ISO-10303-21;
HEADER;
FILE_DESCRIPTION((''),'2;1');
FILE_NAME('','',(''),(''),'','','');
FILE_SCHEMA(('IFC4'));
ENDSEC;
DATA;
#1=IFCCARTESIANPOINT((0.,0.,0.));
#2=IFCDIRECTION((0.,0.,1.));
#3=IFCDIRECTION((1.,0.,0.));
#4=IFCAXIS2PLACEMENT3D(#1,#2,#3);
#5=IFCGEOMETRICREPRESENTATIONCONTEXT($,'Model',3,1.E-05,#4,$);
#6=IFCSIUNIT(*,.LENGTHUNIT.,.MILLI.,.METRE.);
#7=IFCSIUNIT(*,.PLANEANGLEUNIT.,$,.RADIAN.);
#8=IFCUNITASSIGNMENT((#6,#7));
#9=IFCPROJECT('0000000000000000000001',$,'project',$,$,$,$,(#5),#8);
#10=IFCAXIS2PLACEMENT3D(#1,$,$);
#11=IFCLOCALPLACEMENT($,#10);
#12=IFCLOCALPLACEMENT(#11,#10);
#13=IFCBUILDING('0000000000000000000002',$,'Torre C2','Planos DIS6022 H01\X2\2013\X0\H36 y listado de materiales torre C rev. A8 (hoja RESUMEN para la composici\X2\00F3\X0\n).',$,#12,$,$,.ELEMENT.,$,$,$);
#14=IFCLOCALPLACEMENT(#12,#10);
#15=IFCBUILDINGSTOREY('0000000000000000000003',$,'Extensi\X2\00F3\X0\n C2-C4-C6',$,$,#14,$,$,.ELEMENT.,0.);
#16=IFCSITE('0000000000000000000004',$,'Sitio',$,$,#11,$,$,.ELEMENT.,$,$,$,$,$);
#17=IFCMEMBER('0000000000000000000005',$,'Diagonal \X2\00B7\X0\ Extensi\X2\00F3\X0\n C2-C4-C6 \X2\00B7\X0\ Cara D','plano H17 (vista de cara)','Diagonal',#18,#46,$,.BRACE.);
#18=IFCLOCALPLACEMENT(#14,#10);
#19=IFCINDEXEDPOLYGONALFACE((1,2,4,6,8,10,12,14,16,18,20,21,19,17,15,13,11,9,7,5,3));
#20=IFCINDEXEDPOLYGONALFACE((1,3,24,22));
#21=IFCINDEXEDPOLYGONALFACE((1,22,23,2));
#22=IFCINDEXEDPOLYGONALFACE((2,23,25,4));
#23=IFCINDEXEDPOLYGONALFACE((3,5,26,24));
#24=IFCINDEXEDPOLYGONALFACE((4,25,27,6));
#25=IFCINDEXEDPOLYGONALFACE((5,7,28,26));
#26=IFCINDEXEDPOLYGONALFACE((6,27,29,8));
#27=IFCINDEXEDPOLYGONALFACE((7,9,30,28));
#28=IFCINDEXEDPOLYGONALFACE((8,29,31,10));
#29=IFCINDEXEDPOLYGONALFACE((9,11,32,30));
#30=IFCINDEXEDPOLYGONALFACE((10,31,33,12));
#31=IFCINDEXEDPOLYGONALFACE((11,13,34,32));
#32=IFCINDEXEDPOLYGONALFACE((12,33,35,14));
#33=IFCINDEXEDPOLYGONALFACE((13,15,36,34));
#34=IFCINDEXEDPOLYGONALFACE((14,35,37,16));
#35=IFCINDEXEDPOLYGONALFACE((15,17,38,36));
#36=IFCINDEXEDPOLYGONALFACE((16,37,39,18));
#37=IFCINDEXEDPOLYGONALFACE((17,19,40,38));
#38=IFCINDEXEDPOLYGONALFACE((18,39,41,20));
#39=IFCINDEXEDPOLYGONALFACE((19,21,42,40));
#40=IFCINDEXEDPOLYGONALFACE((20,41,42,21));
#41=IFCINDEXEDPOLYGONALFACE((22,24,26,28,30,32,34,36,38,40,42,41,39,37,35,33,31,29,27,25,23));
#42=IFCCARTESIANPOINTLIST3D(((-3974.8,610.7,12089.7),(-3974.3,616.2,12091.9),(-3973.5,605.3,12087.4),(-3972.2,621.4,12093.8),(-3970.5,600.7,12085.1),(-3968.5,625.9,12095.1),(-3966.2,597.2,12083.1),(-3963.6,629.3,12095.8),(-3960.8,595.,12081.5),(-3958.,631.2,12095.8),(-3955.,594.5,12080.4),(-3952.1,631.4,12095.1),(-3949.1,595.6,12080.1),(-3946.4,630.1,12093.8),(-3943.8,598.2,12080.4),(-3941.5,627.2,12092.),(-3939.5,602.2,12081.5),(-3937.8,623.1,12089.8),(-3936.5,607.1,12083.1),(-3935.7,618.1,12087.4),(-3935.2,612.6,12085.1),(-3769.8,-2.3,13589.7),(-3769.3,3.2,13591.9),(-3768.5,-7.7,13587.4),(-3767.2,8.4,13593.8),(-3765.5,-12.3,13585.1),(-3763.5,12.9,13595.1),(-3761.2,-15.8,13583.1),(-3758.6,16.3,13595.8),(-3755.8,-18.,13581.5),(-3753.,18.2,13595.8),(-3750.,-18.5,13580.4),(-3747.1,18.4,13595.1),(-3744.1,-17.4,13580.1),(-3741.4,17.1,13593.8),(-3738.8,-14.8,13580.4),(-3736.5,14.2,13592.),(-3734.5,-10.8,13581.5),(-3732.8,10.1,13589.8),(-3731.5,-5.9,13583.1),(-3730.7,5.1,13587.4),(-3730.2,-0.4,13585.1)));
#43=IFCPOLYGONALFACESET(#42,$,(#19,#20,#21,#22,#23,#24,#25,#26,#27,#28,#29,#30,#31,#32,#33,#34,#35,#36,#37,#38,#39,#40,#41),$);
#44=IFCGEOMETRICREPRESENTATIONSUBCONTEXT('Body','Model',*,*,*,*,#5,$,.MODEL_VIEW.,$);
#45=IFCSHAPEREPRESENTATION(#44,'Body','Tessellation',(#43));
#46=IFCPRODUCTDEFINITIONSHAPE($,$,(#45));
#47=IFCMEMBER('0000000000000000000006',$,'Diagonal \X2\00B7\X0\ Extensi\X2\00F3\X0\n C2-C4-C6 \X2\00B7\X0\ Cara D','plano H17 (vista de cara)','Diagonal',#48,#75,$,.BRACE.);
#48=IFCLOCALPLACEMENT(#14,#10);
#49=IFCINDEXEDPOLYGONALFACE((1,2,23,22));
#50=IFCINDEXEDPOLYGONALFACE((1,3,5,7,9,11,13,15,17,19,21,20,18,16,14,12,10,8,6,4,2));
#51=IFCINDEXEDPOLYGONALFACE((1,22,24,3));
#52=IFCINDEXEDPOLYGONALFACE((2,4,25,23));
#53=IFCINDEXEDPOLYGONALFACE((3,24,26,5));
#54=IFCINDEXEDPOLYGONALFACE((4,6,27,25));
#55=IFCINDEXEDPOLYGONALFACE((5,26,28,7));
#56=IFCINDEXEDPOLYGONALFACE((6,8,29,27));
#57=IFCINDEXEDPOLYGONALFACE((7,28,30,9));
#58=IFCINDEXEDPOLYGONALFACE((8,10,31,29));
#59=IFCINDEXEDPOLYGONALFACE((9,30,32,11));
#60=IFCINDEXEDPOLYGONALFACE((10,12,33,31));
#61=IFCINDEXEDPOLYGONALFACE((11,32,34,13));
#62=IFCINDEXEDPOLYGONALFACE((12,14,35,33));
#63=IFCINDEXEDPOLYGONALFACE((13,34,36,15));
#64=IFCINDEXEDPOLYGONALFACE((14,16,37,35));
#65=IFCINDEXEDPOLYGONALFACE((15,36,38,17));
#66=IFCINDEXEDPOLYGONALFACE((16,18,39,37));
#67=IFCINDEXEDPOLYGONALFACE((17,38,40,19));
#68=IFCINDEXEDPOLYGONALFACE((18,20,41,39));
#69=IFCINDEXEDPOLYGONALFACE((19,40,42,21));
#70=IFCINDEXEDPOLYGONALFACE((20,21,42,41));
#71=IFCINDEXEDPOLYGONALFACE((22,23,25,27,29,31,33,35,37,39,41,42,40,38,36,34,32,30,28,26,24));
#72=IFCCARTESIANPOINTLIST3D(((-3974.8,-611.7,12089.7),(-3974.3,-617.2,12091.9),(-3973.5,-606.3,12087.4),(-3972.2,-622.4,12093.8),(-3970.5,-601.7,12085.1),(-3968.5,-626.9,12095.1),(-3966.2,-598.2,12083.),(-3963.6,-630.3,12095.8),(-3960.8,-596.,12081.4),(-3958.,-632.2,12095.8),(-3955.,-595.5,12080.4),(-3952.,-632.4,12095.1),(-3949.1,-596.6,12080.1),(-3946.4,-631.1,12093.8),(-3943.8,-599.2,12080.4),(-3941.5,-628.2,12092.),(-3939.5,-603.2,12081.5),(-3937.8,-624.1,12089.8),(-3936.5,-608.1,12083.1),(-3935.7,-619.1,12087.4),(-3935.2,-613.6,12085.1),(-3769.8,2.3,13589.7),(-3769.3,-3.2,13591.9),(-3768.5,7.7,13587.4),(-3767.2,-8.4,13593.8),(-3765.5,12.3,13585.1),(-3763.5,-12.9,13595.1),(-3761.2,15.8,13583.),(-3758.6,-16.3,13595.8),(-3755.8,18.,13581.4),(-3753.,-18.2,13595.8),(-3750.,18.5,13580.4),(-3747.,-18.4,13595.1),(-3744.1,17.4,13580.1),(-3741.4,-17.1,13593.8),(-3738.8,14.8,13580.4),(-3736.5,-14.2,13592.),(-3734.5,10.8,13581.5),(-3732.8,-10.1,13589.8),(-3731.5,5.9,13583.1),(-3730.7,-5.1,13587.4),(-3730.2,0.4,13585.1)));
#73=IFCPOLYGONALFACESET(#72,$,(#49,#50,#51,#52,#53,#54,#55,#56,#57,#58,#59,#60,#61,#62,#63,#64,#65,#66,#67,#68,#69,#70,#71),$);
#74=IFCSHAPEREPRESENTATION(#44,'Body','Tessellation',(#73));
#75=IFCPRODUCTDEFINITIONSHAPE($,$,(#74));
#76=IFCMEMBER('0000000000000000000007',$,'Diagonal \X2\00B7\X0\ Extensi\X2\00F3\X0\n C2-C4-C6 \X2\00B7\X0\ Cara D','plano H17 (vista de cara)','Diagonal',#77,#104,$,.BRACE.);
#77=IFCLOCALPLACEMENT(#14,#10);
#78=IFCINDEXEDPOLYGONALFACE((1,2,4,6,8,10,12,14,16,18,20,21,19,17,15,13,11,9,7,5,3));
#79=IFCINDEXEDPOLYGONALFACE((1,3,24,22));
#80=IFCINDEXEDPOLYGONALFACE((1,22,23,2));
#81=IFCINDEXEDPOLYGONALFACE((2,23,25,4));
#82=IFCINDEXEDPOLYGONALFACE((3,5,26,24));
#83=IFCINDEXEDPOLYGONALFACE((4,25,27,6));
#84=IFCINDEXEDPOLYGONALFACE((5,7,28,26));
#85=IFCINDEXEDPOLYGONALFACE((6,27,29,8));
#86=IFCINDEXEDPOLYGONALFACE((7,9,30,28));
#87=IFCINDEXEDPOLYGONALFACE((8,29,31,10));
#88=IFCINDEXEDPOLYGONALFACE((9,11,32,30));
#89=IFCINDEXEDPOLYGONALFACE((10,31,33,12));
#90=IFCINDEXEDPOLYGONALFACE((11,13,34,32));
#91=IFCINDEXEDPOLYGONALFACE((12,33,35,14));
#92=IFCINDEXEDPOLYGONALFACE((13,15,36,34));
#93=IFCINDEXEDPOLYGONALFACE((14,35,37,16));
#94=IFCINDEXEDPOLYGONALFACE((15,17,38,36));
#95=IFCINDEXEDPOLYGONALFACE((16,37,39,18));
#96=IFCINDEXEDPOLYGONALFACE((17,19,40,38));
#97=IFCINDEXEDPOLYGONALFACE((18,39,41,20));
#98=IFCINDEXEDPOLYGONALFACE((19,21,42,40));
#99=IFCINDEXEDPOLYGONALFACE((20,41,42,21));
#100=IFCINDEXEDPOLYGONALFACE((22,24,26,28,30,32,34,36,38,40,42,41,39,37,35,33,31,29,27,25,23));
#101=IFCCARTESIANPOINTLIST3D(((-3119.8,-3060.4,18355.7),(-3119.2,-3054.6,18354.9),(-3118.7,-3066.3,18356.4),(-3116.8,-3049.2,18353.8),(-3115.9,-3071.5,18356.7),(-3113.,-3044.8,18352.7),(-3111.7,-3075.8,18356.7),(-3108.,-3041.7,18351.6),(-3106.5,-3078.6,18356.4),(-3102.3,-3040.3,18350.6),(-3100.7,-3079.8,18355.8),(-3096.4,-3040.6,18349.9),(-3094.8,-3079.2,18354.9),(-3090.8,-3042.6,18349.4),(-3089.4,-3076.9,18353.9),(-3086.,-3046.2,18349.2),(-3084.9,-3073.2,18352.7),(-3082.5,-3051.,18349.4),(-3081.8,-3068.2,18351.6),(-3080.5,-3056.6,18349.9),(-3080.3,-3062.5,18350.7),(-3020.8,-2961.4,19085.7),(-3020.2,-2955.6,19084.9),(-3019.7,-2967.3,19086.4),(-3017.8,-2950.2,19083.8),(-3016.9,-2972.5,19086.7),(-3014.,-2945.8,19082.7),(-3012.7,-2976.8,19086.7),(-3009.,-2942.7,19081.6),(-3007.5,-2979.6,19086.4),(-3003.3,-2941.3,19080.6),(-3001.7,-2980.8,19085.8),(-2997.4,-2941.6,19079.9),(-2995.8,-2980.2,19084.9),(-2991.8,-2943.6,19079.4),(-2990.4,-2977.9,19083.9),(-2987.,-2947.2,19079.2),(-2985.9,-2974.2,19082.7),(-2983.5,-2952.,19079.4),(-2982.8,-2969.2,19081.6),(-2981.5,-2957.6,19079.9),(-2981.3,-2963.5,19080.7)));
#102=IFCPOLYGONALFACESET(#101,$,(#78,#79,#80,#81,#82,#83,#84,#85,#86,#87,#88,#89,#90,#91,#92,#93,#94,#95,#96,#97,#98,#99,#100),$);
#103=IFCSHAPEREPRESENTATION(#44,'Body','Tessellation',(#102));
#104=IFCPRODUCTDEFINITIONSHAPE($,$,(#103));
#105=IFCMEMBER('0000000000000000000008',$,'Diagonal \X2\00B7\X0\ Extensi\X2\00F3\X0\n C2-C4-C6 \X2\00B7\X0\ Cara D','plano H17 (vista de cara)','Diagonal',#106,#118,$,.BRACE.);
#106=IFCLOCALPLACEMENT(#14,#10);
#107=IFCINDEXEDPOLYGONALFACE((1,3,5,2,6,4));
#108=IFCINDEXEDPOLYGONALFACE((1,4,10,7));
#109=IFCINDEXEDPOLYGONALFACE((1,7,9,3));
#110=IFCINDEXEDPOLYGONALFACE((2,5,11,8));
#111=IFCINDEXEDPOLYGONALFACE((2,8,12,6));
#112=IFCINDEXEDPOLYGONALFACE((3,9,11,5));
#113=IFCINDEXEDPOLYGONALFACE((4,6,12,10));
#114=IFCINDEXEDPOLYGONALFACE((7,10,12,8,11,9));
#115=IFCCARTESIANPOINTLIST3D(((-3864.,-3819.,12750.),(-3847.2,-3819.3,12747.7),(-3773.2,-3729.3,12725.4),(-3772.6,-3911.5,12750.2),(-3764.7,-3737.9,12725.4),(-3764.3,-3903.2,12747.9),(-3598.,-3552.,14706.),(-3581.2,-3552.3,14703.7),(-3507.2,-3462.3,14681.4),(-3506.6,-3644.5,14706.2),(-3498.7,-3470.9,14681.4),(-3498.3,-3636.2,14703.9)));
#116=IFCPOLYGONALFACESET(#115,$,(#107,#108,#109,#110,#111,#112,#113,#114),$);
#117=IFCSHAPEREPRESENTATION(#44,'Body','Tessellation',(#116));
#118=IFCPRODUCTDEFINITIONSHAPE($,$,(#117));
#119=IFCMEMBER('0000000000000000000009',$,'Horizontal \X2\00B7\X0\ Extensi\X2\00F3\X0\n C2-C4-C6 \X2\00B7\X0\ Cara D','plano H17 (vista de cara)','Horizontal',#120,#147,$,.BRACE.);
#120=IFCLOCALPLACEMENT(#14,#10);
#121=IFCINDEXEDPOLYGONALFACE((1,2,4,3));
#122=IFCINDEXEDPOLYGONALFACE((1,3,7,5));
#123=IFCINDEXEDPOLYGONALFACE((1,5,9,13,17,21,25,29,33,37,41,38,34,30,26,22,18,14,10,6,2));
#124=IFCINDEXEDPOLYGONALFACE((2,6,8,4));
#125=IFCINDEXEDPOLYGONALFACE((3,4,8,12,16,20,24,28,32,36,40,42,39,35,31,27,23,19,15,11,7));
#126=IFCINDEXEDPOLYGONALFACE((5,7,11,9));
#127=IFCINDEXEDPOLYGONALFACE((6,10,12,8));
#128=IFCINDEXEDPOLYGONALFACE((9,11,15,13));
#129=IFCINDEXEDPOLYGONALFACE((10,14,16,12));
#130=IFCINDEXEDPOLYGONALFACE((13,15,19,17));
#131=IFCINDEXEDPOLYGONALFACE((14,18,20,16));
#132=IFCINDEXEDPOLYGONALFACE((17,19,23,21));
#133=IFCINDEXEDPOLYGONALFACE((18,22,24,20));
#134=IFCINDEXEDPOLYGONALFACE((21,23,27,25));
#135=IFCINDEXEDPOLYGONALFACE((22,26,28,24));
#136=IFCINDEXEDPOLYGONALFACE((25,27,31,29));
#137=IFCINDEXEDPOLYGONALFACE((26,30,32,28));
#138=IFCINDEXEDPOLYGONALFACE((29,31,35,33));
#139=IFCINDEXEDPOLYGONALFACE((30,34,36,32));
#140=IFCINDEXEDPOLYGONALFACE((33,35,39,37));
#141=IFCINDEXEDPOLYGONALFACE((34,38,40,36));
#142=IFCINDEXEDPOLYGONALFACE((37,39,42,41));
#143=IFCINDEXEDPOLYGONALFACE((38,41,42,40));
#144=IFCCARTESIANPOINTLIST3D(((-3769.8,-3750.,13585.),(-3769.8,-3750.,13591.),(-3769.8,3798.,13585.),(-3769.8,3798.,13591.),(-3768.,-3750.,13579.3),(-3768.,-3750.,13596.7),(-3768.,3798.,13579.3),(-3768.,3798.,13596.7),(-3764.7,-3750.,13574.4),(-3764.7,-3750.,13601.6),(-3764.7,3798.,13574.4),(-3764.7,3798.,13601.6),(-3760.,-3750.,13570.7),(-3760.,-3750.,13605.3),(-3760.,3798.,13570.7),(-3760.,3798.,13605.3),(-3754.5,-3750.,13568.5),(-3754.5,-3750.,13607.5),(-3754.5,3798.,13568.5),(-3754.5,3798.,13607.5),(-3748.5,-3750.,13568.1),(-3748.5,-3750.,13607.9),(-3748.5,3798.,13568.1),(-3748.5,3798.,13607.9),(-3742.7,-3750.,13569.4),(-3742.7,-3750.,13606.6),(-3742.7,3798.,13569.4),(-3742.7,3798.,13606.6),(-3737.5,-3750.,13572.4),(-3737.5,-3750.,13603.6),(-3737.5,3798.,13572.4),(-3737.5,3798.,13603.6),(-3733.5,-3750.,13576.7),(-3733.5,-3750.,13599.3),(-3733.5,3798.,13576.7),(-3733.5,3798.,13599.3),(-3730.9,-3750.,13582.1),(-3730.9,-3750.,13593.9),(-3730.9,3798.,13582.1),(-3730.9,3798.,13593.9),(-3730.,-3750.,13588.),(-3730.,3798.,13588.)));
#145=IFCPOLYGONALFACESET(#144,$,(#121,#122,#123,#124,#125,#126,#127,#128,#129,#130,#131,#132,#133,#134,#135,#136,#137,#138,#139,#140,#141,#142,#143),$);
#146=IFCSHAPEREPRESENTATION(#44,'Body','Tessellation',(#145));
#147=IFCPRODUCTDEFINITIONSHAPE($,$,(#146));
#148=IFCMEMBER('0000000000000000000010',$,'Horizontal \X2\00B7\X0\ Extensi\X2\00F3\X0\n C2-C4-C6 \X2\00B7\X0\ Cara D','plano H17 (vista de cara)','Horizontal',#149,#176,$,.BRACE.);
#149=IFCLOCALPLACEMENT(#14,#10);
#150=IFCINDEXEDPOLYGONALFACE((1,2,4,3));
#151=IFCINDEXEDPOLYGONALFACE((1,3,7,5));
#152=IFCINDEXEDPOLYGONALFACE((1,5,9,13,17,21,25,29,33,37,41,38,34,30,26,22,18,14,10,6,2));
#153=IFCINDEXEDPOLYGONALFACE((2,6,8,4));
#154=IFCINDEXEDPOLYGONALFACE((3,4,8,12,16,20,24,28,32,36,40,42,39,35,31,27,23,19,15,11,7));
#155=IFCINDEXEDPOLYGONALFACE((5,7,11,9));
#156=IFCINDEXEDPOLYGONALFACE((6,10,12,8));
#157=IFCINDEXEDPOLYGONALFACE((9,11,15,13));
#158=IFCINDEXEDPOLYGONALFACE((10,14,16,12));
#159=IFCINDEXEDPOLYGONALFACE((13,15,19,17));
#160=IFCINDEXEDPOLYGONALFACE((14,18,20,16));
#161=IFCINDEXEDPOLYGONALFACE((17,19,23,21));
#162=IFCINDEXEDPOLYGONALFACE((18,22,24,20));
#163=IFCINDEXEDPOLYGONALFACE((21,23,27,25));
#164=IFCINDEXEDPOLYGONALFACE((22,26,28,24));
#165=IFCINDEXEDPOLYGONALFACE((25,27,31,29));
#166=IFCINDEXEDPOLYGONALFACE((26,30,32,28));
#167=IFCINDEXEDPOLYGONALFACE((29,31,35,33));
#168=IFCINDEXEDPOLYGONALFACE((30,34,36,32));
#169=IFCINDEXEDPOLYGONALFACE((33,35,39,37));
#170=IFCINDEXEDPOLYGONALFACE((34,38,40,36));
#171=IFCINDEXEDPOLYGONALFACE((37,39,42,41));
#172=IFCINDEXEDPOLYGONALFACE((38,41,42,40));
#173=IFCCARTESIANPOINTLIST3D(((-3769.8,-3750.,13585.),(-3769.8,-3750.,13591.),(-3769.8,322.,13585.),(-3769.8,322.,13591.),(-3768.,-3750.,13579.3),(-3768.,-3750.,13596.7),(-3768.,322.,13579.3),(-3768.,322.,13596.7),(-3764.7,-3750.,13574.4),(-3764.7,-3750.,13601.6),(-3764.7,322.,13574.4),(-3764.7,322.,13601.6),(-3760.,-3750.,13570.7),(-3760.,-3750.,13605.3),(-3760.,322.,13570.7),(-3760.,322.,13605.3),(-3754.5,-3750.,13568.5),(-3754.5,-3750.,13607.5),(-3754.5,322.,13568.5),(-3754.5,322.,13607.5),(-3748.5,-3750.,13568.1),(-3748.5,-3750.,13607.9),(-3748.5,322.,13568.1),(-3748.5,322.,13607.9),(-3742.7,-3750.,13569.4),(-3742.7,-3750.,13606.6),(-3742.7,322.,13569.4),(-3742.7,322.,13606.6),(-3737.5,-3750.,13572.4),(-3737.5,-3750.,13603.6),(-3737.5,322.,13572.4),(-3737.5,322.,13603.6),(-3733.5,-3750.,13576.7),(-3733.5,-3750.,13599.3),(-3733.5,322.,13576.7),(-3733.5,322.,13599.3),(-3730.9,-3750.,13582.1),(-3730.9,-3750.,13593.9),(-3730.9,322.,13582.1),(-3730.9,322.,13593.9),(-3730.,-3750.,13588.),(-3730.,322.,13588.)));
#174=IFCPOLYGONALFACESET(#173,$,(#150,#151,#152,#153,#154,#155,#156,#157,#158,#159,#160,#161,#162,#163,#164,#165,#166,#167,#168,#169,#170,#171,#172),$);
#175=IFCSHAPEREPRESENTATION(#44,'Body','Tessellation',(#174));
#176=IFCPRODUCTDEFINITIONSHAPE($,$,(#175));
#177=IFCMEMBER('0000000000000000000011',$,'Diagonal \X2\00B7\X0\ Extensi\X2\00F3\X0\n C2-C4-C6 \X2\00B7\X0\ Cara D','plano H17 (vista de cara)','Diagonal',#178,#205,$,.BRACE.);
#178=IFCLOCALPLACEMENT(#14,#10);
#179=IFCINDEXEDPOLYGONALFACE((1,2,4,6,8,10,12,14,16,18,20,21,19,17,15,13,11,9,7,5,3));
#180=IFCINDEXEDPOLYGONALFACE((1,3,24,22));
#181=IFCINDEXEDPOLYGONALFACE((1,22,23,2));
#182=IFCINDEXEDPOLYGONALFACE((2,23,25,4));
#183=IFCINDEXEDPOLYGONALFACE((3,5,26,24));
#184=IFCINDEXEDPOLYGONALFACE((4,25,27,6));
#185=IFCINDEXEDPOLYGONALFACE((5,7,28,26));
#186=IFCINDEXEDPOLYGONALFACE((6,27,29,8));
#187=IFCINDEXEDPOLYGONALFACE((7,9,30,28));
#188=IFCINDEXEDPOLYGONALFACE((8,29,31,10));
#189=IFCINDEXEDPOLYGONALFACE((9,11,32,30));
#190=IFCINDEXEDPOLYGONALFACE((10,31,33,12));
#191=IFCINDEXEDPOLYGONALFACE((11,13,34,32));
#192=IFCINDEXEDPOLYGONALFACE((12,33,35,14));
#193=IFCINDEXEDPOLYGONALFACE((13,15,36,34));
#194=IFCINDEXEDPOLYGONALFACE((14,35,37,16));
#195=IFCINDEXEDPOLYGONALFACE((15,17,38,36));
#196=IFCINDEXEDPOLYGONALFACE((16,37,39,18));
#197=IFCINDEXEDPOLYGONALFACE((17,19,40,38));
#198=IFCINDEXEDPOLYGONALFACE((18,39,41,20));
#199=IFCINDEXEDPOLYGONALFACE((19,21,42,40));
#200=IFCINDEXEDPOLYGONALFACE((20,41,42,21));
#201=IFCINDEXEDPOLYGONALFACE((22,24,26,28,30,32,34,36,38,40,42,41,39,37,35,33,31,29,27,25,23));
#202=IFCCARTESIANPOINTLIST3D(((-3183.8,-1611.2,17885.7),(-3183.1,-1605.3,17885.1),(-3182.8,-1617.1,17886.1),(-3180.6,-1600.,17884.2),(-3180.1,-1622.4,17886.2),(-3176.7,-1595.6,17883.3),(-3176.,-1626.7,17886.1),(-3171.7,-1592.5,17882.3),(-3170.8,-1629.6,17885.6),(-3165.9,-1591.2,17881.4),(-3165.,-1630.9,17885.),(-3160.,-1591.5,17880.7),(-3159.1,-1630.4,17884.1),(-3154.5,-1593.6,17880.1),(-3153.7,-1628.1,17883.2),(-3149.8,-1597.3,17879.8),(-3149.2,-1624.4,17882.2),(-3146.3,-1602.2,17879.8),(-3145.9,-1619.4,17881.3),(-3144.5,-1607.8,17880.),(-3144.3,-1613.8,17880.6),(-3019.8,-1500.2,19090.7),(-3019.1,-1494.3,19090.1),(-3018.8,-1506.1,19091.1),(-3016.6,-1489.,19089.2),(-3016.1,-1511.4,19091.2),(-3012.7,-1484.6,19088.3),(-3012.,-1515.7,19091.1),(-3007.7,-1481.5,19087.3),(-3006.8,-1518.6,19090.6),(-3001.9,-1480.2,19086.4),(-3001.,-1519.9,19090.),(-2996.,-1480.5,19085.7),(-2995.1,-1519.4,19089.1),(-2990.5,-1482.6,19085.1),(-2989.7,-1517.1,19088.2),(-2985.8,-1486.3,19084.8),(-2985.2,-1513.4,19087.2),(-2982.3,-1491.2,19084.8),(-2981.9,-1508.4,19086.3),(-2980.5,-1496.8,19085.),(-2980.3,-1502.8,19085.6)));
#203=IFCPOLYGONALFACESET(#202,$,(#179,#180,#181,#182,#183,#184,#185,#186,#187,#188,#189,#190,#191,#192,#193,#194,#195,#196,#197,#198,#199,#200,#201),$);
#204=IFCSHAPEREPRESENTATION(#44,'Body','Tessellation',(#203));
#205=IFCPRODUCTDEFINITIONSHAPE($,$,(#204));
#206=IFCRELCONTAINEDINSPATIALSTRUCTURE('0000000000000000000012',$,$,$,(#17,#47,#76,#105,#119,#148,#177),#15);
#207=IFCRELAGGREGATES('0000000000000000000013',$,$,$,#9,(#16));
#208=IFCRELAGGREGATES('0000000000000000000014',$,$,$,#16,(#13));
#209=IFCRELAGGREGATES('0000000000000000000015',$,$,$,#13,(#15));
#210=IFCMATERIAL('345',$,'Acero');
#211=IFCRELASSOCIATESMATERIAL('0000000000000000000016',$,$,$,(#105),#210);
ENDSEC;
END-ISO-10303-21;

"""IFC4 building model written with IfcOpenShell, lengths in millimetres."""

from ifc_helpers import new_model, si_unit, frame, frame_2d, origin, origin_with_axes, place, context, subcontext, project, spatial, circle, l_section, extrude, material, element, save


model = new_model("IFC4")

# Units and contexts
model_context = context("Model", 3, precision=1e-05, world=origin_with_axes())
body_context = subcontext(model_context, "Body", "Model", "MODEL_VIEW")
ifc_project = project(units=[si_unit("LENGTHUNIT", "METRE", prefix="MILLI"), si_unit("PLANEANGLEUNIT", "RADIAN")], contexts=[model_context])

# Site, building, storey
site_placement = place(None, origin())
site = spatial("IfcSite", under=ifc_project, at=site_placement, Name="Sitio", CompositionType="ELEMENT")
building_placement = place(site_placement, origin())
building = spatial("IfcBuilding", under=site, at=building_placement, Name="Torre C2", Description="Planos DIS6022 H01–H36 y listado de materiales torre C rev. A8 (hoja RESUMEN para la composición).", CompositionType="ELEMENT")
storey_placement = place(building_placement, origin())
storey = spatial("IfcBuildingStorey", under=building, at=storey_placement, Name="Extensión C2-C4-C6", CompositionType="ELEMENT", Elevation=0.0)

# Members
ifc_material_1 = material(Name="345", Category="Acero")
member_1_placement = place(storey_placement, frame((-3750.0, 0.0, 13588.0), z_axis=(-0.12551, 0.375305, -0.918365), x_axis=(0.989349, -0.02144, -0.143973)))
element("IfcMember", 1, at=member_1_placement, inside=storey, Name="Diagonal · Extensión C2-C4-C6 · Cara D", Description="plano H17 (vista de cara)", ObjectType="Diagonal", PredefinedType="BRACE", context=body_context, shape_type="SweptSolid", body=[
    extrude(circle(Radius=20.0), None, (0.0, 0.0, 1.0), 1633.3),
])
member_2_placement = place(storey_placement, frame((-3750.0, 0.0, 13588.0), z_axis=(-0.125481, -0.375831, -0.918153), x_axis=(0.989345, 0.021465, -0.143997)))
element("IfcMember", 2, at=member_2_placement, inside=storey, Name="Diagonal · Extensión C2-C4-C6 · Cara D", Description="plano H17 (vista de cara)", ObjectType="Diagonal", PredefinedType="BRACE", context=body_context, shape_type="SweptSolid", body=[
    extrude(circle(Radius=20.0), None, (0.0, 0.0, 1.0), 1633.7),
])
member_3_placement = place(storey_placement, frame((-3100.0, -3060.0, 18353.0), z_axis=(0.133189, 0.133189, 0.982101), x_axis=(0.699186, 0.689683, -0.188353)))
element("IfcMember", 3, at=member_3_placement, inside=storey, Name="Diagonal · Extensión C2-C4-C6 · Cara D", Description="plano H17 (vista de cara)", ObjectType="Diagonal", PredefinedType="BRACE", context=body_context, shape_type="SweptSolid", body=[
    extrude(circle(Radius=20.0), None, (0.0, 0.0, 1.0), 743.3),
])
member_4_placement = place(storey_placement, frame((-3598.0, -3552.0, 14706.0), z_axis=(-0.133536, -0.134038, -0.981938), x_axis=(0.698788, 0.689855, -0.189197)))
element("IfcMember", 4, at=member_4_placement, inside=storey, material=ifc_material_1, Name="Diagonal · Extensión C2-C4-C6 · Cara D", Description="plano H17 (vista de cara)", ObjectType="Diagonal", PredefinedType="BRACE", context=body_context, shape_type="SweptSolid", body=[
    extrude(l_section(Depth=130.0, Width=130.0, Thickness=12.0, at=frame_2d((65.0, 65.0))), None, (0.0, 0.0, 1.0), 1992.0),
])
member_5_placement = place(storey_placement, frame((-3750.0, -3750.0, 13588.0), z_axis=(0.0, 1.0, 0.0), x_axis=(1.0, 0.0, 0.0)))
element("IfcMember", 5, at=member_5_placement, inside=storey, Name="Horizontal · Extensión C2-C4-C6 · Cara D", Description="plano H17 (vista de cara)", ObjectType="Horizontal", PredefinedType="BRACE", context=body_context, shape_type="SweptSolid", body=[
    extrude(circle(Radius=20.0), None, (0.0, 0.0, 1.0), 7548.0),
])
member_6_placement = place(storey_placement, frame((-3750.0, -3750.0, 13588.0), z_axis=(0.0, 1.0, 0.0), x_axis=(1.0, 0.0, 0.0)))
element("IfcMember", 6, at=member_6_placement, inside=storey, Name="Horizontal · Extensión C2-C4-C6 · Cara D", Description="plano H17 (vista de cara)", ObjectType="Horizontal", PredefinedType="BRACE", context=body_context, shape_type="SweptSolid", body=[
    extrude(circle(Radius=20.0), None, (0.0, 0.0, 1.0), 4072.0),
])
member_7_placement = place(storey_placement, frame((-3000.0, -1500.0, 19088.0), z_axis=(-0.134298, -0.090897, -0.986763), x_axis=(0.882632, 0.441701, -0.160814)))
element("IfcMember", 7, at=member_7_placement, inside=storey, Name="Diagonal · Extensión C2-C4-C6 · Cara D", Description="plano H17 (vista de cara)", ObjectType="Diagonal", PredefinedType="BRACE", context=body_context, shape_type="SweptSolid", body=[
    extrude(circle(Radius=20.0), None, (0.0, 0.0, 1.0), 1221.2),
])

save(model, "model.ifc")
